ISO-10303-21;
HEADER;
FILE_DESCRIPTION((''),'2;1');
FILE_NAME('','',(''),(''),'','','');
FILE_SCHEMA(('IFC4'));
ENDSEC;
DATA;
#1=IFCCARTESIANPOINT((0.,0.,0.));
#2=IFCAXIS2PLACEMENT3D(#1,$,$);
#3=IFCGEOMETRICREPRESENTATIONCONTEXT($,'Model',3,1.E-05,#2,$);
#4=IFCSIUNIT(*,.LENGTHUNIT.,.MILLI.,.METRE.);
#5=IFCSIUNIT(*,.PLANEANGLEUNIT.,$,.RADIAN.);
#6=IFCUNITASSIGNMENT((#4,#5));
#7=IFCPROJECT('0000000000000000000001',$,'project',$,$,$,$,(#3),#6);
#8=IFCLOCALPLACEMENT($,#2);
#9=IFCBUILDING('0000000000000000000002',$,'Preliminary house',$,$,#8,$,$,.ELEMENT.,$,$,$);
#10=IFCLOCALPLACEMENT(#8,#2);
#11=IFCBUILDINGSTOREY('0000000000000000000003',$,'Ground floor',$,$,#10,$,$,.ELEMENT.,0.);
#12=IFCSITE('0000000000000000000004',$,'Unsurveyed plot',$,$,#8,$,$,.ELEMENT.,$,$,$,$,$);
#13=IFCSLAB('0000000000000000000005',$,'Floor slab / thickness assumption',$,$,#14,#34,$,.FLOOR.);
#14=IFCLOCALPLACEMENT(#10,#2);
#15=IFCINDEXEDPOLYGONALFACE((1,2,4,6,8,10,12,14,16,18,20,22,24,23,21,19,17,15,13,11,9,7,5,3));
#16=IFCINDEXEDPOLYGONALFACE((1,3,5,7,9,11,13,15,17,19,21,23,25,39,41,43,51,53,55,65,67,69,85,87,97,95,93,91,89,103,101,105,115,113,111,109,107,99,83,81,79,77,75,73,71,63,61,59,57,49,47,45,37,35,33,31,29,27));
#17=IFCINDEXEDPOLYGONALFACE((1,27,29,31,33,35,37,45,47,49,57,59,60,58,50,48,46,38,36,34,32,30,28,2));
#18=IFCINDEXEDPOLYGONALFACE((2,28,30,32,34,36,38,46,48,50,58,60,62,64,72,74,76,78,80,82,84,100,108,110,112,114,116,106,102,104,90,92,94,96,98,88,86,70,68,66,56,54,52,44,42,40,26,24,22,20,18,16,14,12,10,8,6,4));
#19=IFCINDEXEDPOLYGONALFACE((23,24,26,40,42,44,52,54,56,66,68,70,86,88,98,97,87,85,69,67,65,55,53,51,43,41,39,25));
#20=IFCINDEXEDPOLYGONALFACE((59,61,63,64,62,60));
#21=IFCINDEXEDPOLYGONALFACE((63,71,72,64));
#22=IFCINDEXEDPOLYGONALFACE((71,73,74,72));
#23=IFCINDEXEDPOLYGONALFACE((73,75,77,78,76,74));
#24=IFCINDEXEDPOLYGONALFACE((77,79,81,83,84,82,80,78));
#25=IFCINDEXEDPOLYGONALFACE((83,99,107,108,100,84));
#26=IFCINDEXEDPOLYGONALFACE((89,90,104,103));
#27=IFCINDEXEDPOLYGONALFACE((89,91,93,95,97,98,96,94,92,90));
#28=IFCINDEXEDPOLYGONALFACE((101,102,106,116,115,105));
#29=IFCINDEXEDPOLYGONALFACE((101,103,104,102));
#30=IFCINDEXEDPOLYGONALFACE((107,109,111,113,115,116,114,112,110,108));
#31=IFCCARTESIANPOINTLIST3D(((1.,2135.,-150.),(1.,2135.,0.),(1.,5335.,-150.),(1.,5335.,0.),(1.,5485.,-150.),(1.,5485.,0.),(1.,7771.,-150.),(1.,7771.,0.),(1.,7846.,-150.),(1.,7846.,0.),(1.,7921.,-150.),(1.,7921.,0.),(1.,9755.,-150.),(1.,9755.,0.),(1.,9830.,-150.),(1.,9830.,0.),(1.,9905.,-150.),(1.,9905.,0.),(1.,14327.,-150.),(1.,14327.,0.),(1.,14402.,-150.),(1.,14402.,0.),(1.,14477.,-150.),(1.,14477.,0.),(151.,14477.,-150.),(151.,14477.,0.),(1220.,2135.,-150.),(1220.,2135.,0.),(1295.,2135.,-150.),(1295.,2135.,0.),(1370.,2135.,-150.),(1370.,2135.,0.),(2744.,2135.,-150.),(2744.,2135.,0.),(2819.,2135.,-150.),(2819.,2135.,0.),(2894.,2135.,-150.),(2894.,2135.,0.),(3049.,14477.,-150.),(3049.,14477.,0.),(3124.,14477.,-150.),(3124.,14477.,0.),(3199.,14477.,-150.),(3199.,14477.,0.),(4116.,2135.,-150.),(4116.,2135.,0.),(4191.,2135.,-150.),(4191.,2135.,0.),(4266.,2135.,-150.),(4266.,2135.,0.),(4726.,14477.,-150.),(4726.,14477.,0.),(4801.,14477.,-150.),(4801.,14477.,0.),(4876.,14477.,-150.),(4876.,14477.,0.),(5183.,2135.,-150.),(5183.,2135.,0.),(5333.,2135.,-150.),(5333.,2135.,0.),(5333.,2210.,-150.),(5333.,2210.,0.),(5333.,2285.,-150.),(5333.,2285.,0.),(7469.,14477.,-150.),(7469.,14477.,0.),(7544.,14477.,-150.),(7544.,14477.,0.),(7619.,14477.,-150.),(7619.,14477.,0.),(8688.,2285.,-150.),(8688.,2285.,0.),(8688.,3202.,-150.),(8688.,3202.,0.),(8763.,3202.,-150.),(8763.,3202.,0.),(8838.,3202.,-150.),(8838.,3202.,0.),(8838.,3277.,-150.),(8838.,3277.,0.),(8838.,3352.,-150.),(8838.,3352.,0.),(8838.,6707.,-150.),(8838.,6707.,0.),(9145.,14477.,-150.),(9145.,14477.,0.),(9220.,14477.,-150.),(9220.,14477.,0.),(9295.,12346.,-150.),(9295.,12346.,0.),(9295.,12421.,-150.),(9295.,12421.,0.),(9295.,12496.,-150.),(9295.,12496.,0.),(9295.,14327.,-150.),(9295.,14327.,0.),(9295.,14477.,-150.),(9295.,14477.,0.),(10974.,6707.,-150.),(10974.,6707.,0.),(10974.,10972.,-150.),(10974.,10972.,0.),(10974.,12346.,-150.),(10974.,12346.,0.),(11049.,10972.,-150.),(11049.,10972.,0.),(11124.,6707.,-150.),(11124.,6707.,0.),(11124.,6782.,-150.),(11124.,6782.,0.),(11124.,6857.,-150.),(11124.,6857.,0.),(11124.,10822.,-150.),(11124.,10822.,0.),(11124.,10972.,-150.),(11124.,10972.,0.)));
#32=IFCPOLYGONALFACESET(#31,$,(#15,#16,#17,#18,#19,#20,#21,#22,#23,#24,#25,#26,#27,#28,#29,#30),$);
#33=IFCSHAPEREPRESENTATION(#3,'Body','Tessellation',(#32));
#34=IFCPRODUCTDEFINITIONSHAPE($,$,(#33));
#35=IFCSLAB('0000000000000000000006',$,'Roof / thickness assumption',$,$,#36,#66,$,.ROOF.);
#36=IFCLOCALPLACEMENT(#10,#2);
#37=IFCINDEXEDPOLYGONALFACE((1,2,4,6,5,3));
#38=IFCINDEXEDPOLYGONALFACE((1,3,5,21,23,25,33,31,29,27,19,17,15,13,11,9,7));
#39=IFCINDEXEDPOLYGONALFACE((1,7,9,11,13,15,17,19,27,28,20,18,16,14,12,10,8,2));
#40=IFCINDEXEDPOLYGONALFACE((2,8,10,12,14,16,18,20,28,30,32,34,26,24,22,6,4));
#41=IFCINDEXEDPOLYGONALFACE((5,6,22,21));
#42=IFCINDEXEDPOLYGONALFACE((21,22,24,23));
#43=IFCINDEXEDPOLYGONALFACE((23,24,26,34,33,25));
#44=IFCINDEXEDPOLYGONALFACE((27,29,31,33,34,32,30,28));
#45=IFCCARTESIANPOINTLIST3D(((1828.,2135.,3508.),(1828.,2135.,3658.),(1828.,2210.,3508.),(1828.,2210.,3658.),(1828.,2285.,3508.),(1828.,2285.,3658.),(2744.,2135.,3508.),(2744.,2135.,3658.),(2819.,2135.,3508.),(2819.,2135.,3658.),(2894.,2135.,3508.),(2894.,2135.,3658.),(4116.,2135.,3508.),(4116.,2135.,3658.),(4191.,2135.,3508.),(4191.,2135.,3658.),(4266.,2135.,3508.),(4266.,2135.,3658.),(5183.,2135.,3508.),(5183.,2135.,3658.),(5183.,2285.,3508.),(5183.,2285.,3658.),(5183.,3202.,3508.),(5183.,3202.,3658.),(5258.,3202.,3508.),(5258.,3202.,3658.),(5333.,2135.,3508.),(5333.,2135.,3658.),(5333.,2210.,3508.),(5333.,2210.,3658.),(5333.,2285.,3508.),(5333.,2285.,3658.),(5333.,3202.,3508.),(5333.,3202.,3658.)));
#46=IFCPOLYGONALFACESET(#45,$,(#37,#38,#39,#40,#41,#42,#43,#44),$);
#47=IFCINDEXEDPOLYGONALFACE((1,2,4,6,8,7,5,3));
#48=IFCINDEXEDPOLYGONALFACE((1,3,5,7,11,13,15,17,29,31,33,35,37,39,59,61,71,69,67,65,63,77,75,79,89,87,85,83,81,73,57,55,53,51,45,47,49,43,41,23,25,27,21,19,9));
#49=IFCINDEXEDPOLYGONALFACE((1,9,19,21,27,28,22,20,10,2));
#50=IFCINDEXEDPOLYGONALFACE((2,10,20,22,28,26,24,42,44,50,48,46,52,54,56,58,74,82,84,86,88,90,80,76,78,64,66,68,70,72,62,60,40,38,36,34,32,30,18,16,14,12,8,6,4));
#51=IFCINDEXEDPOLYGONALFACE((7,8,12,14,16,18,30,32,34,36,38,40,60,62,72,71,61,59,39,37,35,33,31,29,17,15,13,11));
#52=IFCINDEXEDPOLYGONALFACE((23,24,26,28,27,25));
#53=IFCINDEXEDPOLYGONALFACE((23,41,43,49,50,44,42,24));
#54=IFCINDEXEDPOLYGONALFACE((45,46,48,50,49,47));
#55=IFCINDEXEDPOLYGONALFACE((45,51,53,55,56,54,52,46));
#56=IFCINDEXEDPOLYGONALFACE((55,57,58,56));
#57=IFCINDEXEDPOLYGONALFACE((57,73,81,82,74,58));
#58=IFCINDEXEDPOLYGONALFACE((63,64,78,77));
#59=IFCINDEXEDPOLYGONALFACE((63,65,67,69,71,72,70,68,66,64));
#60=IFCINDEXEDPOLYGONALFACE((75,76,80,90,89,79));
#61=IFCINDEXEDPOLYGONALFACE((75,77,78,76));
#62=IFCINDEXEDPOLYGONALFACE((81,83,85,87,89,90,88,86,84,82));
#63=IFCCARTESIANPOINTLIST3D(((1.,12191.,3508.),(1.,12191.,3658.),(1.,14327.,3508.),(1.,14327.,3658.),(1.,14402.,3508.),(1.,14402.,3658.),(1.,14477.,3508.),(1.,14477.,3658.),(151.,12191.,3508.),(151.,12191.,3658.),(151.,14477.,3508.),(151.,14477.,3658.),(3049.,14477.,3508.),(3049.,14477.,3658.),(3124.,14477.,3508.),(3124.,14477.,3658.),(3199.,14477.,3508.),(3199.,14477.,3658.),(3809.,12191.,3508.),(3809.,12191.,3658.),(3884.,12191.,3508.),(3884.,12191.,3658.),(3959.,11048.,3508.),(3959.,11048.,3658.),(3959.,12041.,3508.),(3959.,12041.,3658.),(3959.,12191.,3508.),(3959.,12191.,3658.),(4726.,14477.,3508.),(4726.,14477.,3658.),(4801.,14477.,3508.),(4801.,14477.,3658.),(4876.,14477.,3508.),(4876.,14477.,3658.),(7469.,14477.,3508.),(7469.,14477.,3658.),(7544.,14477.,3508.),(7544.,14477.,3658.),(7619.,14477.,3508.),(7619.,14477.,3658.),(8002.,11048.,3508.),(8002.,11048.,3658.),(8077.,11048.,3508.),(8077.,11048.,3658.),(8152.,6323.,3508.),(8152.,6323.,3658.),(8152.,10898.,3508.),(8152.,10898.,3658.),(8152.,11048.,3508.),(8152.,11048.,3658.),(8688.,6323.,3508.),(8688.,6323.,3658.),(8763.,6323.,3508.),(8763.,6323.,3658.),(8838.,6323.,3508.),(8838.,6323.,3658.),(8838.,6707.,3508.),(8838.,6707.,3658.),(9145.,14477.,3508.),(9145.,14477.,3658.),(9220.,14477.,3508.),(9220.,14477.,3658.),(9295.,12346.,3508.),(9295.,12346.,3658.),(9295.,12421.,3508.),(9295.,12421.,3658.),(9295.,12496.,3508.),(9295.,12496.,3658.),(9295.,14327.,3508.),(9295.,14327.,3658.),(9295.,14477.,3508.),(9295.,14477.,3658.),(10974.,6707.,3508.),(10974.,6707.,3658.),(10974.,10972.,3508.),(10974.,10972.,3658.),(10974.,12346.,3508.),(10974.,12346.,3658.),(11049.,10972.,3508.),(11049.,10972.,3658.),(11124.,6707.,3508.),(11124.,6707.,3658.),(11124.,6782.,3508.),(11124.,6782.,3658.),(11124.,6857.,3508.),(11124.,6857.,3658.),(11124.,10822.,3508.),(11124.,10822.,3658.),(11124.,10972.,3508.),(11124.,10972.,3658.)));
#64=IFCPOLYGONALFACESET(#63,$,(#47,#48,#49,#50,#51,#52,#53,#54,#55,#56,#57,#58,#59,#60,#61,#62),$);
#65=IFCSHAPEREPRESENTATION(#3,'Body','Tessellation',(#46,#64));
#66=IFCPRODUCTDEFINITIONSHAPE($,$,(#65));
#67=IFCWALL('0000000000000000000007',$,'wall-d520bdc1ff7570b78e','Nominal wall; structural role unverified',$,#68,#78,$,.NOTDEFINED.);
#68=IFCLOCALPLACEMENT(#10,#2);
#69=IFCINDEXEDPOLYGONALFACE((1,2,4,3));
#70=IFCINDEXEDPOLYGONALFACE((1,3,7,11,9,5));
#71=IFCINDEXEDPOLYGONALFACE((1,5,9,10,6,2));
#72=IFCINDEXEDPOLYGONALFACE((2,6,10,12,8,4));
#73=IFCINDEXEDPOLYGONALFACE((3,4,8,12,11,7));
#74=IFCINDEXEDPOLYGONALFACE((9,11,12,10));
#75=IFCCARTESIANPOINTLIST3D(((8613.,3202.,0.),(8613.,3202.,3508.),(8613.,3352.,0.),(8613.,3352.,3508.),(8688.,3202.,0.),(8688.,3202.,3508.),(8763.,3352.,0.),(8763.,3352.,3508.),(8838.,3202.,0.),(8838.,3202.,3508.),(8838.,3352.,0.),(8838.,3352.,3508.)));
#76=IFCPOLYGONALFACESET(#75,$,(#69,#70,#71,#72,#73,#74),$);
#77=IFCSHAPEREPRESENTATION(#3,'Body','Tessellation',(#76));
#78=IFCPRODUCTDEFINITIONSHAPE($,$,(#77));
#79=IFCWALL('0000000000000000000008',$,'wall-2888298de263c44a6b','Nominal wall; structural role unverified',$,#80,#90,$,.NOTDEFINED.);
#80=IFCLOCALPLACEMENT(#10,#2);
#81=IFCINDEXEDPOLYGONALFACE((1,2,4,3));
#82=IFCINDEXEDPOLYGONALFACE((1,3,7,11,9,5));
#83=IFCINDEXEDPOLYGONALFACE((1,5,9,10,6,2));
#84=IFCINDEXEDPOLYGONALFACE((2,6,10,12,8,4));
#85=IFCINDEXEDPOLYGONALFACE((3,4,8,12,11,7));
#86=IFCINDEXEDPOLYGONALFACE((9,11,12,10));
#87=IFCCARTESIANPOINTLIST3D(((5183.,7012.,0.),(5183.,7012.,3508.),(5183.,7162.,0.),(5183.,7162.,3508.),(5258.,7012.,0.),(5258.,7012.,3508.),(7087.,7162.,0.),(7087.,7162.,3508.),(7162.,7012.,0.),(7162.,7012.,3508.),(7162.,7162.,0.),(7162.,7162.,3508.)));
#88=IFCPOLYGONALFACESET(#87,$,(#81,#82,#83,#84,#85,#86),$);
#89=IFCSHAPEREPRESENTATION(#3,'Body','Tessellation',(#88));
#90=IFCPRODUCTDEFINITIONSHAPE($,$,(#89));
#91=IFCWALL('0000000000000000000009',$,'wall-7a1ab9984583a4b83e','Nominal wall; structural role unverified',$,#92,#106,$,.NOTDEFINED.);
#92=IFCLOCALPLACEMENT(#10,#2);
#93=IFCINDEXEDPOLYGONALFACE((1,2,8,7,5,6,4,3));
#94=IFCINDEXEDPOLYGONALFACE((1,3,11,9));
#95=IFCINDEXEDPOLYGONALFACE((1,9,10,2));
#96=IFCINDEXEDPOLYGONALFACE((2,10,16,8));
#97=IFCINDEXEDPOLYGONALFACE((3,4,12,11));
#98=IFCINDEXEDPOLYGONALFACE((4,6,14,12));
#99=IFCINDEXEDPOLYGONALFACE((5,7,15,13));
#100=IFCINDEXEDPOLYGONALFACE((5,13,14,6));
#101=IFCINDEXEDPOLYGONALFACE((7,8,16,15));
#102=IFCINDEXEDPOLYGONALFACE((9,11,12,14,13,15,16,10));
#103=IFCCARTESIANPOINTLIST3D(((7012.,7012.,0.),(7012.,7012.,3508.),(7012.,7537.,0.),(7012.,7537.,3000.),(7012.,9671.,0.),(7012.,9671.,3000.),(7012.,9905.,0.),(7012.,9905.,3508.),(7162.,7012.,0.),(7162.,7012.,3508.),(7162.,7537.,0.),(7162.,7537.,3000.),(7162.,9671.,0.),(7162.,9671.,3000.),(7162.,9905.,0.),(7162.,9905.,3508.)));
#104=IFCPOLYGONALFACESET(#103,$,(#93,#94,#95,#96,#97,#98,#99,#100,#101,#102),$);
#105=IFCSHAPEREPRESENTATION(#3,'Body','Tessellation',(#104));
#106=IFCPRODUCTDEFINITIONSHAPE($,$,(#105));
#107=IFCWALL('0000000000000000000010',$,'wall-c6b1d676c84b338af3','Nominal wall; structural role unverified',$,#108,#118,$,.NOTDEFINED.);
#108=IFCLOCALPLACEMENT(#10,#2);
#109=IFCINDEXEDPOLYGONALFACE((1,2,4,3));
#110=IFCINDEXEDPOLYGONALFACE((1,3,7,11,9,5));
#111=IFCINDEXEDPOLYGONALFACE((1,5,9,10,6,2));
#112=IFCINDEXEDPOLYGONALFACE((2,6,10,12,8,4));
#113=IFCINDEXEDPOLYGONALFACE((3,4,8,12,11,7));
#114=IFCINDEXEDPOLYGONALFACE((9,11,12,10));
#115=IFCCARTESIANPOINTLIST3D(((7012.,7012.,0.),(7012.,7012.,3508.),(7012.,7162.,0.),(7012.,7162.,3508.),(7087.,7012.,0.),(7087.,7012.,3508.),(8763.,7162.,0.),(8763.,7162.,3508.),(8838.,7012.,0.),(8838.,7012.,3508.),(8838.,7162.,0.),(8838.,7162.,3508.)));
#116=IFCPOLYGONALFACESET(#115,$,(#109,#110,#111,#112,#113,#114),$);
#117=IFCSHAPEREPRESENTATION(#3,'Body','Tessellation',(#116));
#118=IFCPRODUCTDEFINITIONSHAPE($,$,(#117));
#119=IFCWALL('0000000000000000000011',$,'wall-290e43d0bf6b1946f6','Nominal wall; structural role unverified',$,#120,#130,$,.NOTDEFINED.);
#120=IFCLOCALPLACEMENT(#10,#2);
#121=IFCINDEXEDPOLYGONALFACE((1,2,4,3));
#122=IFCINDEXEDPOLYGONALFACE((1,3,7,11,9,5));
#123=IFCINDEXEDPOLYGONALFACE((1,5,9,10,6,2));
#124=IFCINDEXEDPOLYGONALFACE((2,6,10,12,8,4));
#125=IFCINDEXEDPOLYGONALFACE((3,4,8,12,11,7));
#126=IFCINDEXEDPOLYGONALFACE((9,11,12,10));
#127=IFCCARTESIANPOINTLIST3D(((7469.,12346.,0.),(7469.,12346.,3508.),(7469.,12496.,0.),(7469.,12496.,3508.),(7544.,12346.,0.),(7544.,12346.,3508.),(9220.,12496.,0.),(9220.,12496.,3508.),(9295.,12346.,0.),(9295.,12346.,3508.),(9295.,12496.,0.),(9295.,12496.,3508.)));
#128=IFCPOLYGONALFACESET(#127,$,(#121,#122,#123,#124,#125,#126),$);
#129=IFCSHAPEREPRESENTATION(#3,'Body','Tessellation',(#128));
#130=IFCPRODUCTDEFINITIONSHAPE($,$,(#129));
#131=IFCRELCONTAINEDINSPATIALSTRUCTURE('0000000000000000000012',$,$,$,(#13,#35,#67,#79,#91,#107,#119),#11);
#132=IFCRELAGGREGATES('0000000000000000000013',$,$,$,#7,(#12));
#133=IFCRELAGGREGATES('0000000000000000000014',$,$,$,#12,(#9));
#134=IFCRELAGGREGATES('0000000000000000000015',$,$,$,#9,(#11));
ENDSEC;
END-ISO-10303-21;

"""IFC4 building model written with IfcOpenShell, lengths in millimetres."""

from ifc_helpers import new_model, si_unit, frame, origin, place, context, project, spatial, polyline, outline, extrude, element, save


model = new_model("IFC4")

# Units and contexts
model_context = context("Model", 3, precision=1e-05, world=origin())
ifc_project = project(units=[si_unit("LENGTHUNIT", "METRE", prefix="MILLI"), si_unit("PLANEANGLEUNIT", "RADIAN")], contexts=[model_context])

# Site, building, storey
placement_1 = place(None, origin())
site = spatial("IfcSite", under=ifc_project, at=placement_1, Name="Unsurveyed plot", CompositionType="ELEMENT")
building = spatial("IfcBuilding", under=site, at=placement_1, Name="Preliminary house", CompositionType="ELEMENT")
placement_2 = place(placement_1, origin())
storey = spatial("IfcBuildingStorey", under=building, at=placement_2, Name="Ground floor", CompositionType="ELEMENT", Elevation=0.0)

# Slabs
element("IfcSlab", 1, at=placement_2, inside=storey, Name="Floor slab / thickness assumption", PredefinedType="FLOOR", context=model_context, shape_type="SweptSolid", body=[
    extrude(outline(polyline([(4116.0, 2135.0), (2894.0, 2135.0), (2819.0, 2135.0), (2744.0, 2135.0), (1370.0, 2135.0), (1295.0, 2135.0), (1220.0, 2135.0), (1.0, 2135.0), (1.0, 5335.0), (1.0, 5485.0), (1.0, 7771.0), (1.0, 7846.0), (1.0, 7921.0), (1.0, 9755.0), (1.0, 9830.0), (1.0, 9905.0), (1.0, 14327.0), (1.0, 14402.0), (1.0, 14477.0), (151.0, 14477.0), (3049.0, 14477.0), (3124.0, 14477.0), (3199.0, 14477.0), (4726.0, 14477.0), (4801.0, 14477.0), (4876.0, 14477.0), (7469.0, 14477.0), (7544.0, 14477.0), (7619.0, 14477.0), (9145.0, 14477.0), (9220.0, 14477.0), (9295.0, 14477.0), (9295.0, 14327.0), (9295.0, 12496.0), (9295.0, 12421.0), (9295.0, 12346.0), (10974.0, 12346.0), (10974.0, 10972.0), (11049.0, 10972.0), (11124.0, 10972.0), (11124.0, 10822.0), (11124.0, 6857.0), (11124.0, 6782.0), (11124.0, 6707.0), (10974.0, 6707.0), (8838.0, 6707.0), (8838.0, 3352.0), (8838.0, 3277.0), (8838.0, 3202.0), (8763.0, 3202.0), (8688.0, 3202.0), (8688.0, 2285.0), (5333.0, 2285.0), (5333.0, 2210.0), (5333.0, 2135.0), (5183.0, 2135.0), (4266.0, 2135.0), (4191.0, 2135.0), (4116.0, 2135.0)])), frame((0.0, 0.0, -150.0)), (0.0, 0.0, 1.0), 150.0),
])
element("IfcSlab", 2, at=placement_2, inside=storey, Name="Roof / thickness assumption", PredefinedType="ROOF", context=model_context, shape_type="SweptSolid", body=[
    extrude(outline(polyline([(1828.0, 2210.0), (1828.0, 2285.0), (5183.0, 2285.0), (5183.0, 3202.0), (5258.0, 3202.0), (5333.0, 3202.0), (5333.0, 2285.0), (5333.0, 2210.0), (5333.0, 2135.0), (5183.0, 2135.0), (4266.0, 2135.0), (4191.0, 2135.0), (4116.0, 2135.0), (2894.0, 2135.0), (2819.0, 2135.0), (2744.0, 2135.0), (1828.0, 2135.0), (1828.0, 2210.0)])), frame((0.0, 0.0, 3508.0)), (0.0, 0.0, 1.0), 150.0),
    extrude(outline(polyline([(1.0, 14402.0), (1.0, 14477.0), (151.0, 14477.0), (3049.0, 14477.0), (3124.0, 14477.0), (3199.0, 14477.0), (4726.0, 14477.0), (4801.0, 14477.0), (4876.0, 14477.0), (7469.0, 14477.0), (7544.0, 14477.0), (7619.0, 14477.0), (9145.0, 14477.0), (9220.0, 14477.0), (9295.0, 14477.0), (9295.0, 14327.0), (9295.0, 12496.0), (9295.0, 12421.0), (9295.0, 12346.0), (10974.0, 12346.0), (10974.0, 10972.0), (11049.0, 10972.0), (11124.0, 10972.0), (11124.0, 10822.0), (11124.0, 6857.0), (11124.0, 6782.0), (11124.0, 6707.0), (10974.0, 6707.0), (8838.0, 6707.0), (8838.0, 6323.0), (8763.0, 6323.0), (8688.0, 6323.0), (8152.0, 6323.0), (8152.0, 10898.0), (8152.0, 11048.0), (8077.0, 11048.0), (8002.0, 11048.0), (3959.0, 11048.0), (3959.0, 12041.0), (3959.0, 12191.0), (3884.0, 12191.0), (3809.0, 12191.0), (151.0, 12191.0), (1.0, 12191.0), (1.0, 14327.0), (1.0, 14402.0)])), frame((0.0, 0.0, 3508.0)), (0.0, 0.0, 1.0), 150.0),
])

# Walls
element("IfcWall", 3, at=placement_2, inside=storey, Name="wall-d520bdc1ff7570b78e", Description="Nominal wall; structural role unverified", PredefinedType="NOTDEFINED", context=model_context, shape_type="SweptSolid", body=[
    extrude(outline(polyline([(8763.0, 3352.0), (8838.0, 3352.0), (8838.0, 3202.0), (8688.0, 3202.0), (8613.0, 3202.0), (8613.0, 3352.0), (8763.0, 3352.0)])), origin(), (0.0, 0.0, 1.0), 3508.0),
])
element("IfcWall", 4, at=placement_2, inside=storey, Name="wall-2888298de263c44a6b", Description="Nominal wall; structural role unverified", PredefinedType="NOTDEFINED", context=model_context, shape_type="SweptSolid", body=[
    extrude(outline(polyline([(7087.0, 7162.0), (7162.0, 7162.0), (7162.0, 7012.0), (5258.0, 7012.0), (5183.0, 7012.0), (5183.0, 7162.0), (7087.0, 7162.0)])), origin(), (0.0, 0.0, 1.0), 3508.0),
])

# Wall, opening
wall_1 = element("IfcWall", 5, at=placement_2, inside=storey, Name="wall-7a1ab9984583a4b83e", Description="Nominal wall; structural role unverified", PredefinedType="NOTDEFINED", context=model_context, shape_type="SweptSolid", body=[
    extrude(outline(polyline([(7012.0, 9830.0), (7012.0, 9905.0), (7162.0, 9905.0), (7162.0, 7087.0), (7162.0, 7012.0), (7012.0, 7012.0), (7012.0, 9830.0)])), origin(), (0.0, 0.0, 1.0), 3508.0),
])
element("IfcOpeningElement", 6, at=placement_2, cuts=wall_1, PredefinedType="OPENING", context=model_context, shape_type="SweptSolid", body=[
    extrude(outline(polyline([(7537.0, 7537.0), (7537.0, 9671.0), (6637.0, 9671.0), (6637.0, 7537.0), (7537.0, 7537.0)])), origin(), (0.0, 0.0, 1.0), 3000.0),
])

# Wall
element("IfcWall", 7, at=placement_2, inside=storey, Name="wall-c6b1d676c84b338af3", Description="Nominal wall; structural role unverified", PredefinedType="NOTDEFINED", context=model_context, shape_type="SweptSolid", body=[
    extrude(outline(polyline([(8763.0, 7162.0), (8838.0, 7162.0), (8838.0, 7012.0), (7087.0, 7012.0), (7012.0, 7012.0), (7012.0, 7162.0), (8763.0, 7162.0)])), origin(), (0.0, 0.0, 1.0), 3508.0),
])

# Wall
element("IfcWall", 8, at=placement_2, inside=storey, Name="wall-290e43d0bf6b1946f6", Description="Nominal wall; structural role unverified", PredefinedType="NOTDEFINED", context=model_context, shape_type="SweptSolid", body=[
    extrude(outline(polyline([(9220.0, 12496.0), (9295.0, 12496.0), (9295.0, 12346.0), (7544.0, 12346.0), (7469.0, 12346.0), (7469.0, 12496.0), (9220.0, 12496.0)])), origin(), (0.0, 0.0, 1.0), 3508.0),
])

save(model, "model.ifc")
